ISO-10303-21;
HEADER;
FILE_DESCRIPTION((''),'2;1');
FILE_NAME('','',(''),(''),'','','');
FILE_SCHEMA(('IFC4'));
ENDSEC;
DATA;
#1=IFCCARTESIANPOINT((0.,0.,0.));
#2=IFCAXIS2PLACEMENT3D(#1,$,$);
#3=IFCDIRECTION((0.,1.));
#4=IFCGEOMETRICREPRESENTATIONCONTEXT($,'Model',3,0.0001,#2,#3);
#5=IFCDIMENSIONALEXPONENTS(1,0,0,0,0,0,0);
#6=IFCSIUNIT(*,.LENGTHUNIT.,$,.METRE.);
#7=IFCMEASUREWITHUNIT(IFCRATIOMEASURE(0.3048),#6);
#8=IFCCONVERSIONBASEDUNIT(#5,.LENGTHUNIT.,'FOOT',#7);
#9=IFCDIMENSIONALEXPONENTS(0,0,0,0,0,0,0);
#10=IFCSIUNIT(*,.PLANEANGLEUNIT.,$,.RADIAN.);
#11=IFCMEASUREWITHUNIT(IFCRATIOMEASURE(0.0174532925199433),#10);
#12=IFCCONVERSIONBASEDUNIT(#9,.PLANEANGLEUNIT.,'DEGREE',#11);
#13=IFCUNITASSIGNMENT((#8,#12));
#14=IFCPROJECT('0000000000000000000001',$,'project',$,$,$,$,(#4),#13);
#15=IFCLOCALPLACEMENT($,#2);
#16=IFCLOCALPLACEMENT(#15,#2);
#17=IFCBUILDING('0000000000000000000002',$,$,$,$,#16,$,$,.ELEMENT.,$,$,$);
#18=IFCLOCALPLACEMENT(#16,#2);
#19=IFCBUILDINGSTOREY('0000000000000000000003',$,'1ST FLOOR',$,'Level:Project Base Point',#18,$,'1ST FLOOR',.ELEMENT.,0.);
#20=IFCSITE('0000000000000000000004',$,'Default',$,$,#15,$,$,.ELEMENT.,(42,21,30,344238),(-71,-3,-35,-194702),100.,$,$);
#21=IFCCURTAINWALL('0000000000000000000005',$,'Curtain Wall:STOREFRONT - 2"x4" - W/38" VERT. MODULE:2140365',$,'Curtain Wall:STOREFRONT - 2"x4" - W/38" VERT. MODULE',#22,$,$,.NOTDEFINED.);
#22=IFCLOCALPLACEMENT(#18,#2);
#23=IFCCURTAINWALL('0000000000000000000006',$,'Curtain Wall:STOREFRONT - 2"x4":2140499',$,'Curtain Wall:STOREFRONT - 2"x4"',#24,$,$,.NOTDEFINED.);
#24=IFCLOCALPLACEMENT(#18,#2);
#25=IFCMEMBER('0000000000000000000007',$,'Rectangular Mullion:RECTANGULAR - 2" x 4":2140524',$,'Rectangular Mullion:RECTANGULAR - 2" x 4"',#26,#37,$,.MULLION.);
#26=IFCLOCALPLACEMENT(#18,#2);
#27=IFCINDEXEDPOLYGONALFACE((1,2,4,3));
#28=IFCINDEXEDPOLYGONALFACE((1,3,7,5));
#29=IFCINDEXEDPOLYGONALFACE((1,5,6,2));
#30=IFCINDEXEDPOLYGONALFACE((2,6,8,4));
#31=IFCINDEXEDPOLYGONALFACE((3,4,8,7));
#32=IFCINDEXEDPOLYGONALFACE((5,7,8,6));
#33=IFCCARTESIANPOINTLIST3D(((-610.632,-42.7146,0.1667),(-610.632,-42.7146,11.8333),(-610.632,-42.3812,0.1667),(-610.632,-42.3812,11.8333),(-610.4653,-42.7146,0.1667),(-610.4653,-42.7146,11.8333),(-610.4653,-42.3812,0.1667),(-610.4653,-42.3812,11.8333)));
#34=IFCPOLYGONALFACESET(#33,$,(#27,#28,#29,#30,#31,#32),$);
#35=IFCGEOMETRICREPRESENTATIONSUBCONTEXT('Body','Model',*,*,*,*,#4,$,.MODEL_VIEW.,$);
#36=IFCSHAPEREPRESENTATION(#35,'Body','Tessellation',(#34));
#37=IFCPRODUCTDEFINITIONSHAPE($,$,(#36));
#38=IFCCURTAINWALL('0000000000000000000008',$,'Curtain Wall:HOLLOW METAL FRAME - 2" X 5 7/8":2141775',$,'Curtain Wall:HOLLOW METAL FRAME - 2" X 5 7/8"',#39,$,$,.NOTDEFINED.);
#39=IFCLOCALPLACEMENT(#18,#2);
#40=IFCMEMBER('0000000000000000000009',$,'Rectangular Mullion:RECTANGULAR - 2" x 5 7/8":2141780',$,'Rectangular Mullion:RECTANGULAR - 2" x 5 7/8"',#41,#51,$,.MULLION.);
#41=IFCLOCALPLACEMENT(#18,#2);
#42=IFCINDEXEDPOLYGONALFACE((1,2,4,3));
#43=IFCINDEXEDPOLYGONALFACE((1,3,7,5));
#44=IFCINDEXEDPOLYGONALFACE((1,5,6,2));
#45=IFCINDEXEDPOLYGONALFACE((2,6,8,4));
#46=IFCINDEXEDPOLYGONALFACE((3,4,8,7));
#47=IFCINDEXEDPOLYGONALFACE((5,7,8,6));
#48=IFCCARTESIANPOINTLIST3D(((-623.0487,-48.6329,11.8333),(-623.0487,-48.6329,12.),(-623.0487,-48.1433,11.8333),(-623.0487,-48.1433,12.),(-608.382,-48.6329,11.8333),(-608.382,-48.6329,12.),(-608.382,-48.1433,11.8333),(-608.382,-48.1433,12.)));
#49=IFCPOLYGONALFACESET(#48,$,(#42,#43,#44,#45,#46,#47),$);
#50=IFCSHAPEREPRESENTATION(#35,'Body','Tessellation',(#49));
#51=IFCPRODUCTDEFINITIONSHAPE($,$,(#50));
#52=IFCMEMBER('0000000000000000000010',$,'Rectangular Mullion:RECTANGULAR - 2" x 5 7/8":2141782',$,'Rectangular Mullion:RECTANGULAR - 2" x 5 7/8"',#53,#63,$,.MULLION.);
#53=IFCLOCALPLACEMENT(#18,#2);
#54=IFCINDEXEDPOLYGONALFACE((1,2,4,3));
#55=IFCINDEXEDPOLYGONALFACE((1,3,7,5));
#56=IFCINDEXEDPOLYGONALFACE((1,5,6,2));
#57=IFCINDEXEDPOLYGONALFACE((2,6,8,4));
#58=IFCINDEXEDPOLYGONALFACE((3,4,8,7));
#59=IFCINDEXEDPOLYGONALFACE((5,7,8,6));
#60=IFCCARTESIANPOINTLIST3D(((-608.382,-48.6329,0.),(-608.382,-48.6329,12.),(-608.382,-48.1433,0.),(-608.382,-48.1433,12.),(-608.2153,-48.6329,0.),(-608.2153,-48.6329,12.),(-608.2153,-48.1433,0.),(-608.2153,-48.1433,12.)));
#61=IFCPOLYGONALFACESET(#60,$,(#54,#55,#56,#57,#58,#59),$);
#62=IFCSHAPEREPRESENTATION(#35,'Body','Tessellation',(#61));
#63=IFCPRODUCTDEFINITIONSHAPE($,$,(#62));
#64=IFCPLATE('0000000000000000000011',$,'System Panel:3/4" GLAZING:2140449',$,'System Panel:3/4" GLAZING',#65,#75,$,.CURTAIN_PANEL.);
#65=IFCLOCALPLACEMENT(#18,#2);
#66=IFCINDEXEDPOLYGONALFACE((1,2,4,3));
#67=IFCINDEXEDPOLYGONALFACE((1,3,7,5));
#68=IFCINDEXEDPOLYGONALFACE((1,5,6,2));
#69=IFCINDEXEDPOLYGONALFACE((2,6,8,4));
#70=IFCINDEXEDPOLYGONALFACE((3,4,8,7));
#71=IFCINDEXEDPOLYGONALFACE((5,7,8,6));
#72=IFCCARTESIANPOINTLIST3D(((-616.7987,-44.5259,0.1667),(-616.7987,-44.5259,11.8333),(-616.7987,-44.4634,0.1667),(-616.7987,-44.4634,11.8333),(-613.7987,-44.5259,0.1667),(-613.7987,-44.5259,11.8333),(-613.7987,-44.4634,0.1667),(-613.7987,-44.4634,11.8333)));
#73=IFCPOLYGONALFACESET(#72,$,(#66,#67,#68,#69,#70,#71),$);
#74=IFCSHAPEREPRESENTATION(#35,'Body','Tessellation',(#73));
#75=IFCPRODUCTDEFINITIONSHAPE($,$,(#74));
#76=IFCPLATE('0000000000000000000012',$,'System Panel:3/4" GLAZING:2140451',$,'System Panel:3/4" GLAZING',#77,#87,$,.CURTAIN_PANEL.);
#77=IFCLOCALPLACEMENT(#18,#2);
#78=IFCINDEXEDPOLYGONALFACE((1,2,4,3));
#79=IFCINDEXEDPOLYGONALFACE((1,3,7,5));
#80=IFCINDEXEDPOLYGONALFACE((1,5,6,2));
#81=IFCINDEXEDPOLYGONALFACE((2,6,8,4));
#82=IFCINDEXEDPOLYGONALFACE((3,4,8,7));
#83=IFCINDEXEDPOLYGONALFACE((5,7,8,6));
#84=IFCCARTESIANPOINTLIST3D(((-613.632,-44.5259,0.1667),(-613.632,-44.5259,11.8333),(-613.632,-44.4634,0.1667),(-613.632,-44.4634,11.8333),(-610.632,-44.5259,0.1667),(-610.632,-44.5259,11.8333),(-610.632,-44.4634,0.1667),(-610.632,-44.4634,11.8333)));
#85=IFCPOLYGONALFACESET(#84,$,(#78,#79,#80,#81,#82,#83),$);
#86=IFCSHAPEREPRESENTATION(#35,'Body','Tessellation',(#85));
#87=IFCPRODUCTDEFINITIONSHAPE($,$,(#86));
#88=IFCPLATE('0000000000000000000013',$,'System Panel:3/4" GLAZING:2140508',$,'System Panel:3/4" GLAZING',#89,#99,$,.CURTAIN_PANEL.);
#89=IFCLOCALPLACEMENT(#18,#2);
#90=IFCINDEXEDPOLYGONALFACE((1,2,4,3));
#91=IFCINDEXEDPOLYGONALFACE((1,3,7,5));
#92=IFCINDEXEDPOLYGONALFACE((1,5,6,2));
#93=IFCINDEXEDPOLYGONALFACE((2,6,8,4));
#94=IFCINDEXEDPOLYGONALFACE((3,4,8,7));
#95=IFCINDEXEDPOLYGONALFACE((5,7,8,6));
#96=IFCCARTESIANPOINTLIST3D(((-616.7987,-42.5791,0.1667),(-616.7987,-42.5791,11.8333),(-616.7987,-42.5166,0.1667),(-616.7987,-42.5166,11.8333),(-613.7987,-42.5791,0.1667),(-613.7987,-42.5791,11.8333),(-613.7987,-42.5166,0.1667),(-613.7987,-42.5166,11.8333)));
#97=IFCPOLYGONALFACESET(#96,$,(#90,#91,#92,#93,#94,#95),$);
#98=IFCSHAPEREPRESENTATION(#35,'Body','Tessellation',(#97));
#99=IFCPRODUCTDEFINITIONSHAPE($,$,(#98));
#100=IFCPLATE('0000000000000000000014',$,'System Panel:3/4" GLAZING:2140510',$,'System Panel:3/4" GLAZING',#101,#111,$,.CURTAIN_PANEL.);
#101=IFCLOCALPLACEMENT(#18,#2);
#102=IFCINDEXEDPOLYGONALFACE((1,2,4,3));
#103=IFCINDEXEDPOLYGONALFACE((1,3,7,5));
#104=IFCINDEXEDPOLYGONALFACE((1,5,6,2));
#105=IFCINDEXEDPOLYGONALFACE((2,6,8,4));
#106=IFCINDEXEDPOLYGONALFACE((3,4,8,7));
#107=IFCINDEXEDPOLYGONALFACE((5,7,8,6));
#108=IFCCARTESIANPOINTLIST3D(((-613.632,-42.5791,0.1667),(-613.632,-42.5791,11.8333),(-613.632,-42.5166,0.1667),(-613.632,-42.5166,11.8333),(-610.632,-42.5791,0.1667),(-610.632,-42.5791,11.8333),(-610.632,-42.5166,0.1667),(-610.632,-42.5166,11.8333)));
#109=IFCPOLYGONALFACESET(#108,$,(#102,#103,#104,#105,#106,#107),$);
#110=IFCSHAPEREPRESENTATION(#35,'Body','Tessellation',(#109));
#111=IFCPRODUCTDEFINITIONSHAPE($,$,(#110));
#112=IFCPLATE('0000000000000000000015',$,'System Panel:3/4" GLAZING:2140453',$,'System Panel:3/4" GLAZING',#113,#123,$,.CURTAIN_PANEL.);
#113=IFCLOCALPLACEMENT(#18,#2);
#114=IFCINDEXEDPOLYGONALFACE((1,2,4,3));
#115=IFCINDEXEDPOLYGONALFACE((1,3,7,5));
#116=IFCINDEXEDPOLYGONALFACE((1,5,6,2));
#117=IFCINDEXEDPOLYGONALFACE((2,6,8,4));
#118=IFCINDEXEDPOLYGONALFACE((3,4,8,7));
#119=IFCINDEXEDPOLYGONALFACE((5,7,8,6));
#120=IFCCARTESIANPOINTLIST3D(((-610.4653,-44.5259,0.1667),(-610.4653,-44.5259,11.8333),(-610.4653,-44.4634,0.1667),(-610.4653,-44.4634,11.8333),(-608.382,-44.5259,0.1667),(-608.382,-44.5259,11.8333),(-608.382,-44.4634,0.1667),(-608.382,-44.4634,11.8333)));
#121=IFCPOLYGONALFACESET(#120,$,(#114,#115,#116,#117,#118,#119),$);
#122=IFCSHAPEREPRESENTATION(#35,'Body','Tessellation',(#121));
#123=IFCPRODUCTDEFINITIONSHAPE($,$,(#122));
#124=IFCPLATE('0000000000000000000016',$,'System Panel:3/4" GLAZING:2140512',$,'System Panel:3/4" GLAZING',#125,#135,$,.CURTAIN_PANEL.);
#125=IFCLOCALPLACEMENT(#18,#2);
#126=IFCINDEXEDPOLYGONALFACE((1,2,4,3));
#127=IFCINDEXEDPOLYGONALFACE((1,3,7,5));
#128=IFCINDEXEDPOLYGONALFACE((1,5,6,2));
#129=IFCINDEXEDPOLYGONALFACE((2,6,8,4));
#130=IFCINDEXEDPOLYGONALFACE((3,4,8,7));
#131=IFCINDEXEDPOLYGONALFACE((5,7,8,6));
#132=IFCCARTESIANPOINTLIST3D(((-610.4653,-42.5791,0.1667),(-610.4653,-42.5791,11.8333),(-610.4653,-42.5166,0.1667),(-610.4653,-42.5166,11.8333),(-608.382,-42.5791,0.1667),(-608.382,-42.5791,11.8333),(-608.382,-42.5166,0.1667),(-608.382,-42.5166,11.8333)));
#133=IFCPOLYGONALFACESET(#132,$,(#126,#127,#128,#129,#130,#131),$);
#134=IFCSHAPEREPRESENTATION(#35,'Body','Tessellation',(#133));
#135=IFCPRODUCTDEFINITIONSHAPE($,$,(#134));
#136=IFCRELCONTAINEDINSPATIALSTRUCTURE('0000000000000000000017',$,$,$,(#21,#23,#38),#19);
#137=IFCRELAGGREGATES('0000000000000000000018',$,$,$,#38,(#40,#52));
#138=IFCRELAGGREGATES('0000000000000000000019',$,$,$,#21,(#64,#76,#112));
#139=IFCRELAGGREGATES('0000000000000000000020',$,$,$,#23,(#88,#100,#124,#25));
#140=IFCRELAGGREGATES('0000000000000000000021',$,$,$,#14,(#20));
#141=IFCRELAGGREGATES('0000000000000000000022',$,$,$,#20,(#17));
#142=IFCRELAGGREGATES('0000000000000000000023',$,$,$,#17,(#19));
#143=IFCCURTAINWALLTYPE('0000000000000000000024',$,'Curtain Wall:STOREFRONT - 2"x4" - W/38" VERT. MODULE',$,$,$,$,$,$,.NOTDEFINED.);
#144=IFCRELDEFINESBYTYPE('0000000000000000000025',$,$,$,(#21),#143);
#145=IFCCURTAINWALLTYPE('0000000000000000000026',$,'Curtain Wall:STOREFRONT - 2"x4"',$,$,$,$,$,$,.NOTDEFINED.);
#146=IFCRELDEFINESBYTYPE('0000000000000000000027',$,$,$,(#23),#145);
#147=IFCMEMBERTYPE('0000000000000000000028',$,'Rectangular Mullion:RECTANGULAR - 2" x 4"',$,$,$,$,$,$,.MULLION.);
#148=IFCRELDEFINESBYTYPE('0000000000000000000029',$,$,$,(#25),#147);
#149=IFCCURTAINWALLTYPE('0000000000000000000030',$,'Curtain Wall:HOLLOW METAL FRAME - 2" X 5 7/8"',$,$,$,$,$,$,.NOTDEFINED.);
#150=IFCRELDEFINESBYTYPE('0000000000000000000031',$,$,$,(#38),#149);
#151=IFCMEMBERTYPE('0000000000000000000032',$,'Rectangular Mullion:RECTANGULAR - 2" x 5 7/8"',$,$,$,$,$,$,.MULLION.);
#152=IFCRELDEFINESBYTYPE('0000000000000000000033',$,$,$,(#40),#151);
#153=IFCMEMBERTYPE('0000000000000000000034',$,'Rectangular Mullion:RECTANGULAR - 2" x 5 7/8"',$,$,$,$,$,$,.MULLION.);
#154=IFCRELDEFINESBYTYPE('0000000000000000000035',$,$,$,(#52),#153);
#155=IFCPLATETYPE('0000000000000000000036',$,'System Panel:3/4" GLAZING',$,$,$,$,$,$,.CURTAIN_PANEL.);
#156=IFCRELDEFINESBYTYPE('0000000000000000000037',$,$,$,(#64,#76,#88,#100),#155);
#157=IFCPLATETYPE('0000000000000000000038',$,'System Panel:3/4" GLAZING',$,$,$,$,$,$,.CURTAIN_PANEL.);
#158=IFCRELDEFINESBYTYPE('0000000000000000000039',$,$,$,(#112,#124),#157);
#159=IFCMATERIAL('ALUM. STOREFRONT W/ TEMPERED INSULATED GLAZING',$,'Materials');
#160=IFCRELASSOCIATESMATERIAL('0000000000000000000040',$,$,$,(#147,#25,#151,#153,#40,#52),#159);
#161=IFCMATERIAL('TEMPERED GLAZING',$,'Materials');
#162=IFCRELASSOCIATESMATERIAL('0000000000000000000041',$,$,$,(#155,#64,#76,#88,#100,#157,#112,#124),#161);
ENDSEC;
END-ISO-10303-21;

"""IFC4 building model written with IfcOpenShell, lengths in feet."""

from ifc_helpers import new_model, entity, si_unit, converted_unit, direction, frame, origin, origin_2d_with_axis, place, context, subcontext, project, spatial, rectangle, extrude, source, transform, mapped, material, material_profile, profile_set, profile_usage, type_object, type_shapes, element, aggregate, save


model = new_model("IFC4")

# Units and contexts
model_context = context("Model", 3, precision=0.0001, world=origin(), true_north=direction((0.0, 1.0)))
body_context = subcontext(model_context, "Body", "Model", "MODEL_VIEW")
ifc_project = project(units=[converted_unit("LENGTHUNIT", "FOOT", entity("IfcRatioMeasure", 0.3048), si_unit("LENGTHUNIT", "METRE"), dimensions=[1, 0, 0, 0, 0, 0, 0]), converted_unit("PLANEANGLEUNIT", "DEGREE", entity("IfcRatioMeasure", 0.0174532925199433), si_unit("PLANEANGLEUNIT", "RADIAN"), dimensions=[0, 0, 0, 0, 0, 0, 0])], contexts=[model_context])

# Site, building, storey
site_placement = place(None, origin())
site = spatial("IfcSite", under=ifc_project, at=site_placement, Name="Default", CompositionType="ELEMENT", RefLatitude=(42, 21, 30, 344238), RefLongitude=(-71, -3, -35, -194702), RefElevation=100.0)
building_placement = place(site_placement, origin())
building = spatial("IfcBuilding", under=site, at=building_placement, CompositionType="ELEMENT")
storey_placement = place(building_placement, origin())
storey = spatial("IfcBuildingStorey", under=building, at=storey_placement, Name="1ST FLOOR", ObjectType="Level:Project Base Point", LongName="1ST FLOOR", CompositionType="ELEMENT", Elevation=0.0)

# Curtain walls
curtain_wall_type_1 = type_object("IfcCurtainWallType", Name="Curtain Wall:STOREFRONT - 2\"x4\" - W/38\" VERT. MODULE", PredefinedType="NOTDEFINED")
curtain_wall_1_placement = place(storey_placement, origin())
curtain_wall_1 = element("IfcCurtainWall", 1, at=curtain_wall_1_placement, inside=storey, type_object=curtain_wall_type_1, Name="Curtain Wall:STOREFRONT - 2\"x4\" - W/38\" VERT. MODULE:2140365", ObjectType="Curtain Wall:STOREFRONT - 2\"x4\" - W/38\" VERT. MODULE", PredefinedType="NOTDEFINED")
ifc_material_1 = material(Name="ALUM. STOREFRONT W/ TEMPERED INSULATED GLAZING", Category="Materials")
ifc_material_profile_1 = material_profile(ifc_material_1, rectangle(XDim=0.3333, YDim=0.1667, at=origin_2d_with_axis()), Name="RECTANGULAR - 2\" x 4\"")
ifc_profile_set_1 = profile_set([ifc_material_profile_1], Name="RECTANGULAR - 2\" x 4\"")
curtain_wall_type_2 = type_object("IfcCurtainWallType", Name="Curtain Wall:STOREFRONT - 2\"x4\"", PredefinedType="NOTDEFINED")
curtain_wall_2_placement = place(storey_placement, origin())
curtain_wall_2 = element("IfcCurtainWall", 2, at=curtain_wall_2_placement, inside=storey, type_object=curtain_wall_type_2, Name="Curtain Wall:STOREFRONT - 2\"x4\":2140499", ObjectType="Curtain Wall:STOREFRONT - 2\"x4\"", PredefinedType="NOTDEFINED")

# Member
member_type_1 = type_object("IfcMemberType", Name="Rectangular Mullion:RECTANGULAR - 2\" x 4\"", PredefinedType="MULLION", material=ifc_profile_set_1)
shared_shape_1 = source(origin(), body_context, "Body", "SweptSolid", [
    extrude(rectangle(XDim=0.3333, YDim=0.1667, at=origin_2d_with_axis()), frame((0.0, 0.0, -11.6667), z_axis=(0.0, 0.0, 1.0), x_axis=(0.0, -1.0, 0.0)), (0.0, 0.0, 1.0), 11.6667),
])
type_shapes(member_type_1, [shared_shape_1])
ifc_profile_usage_1 = profile_usage(ifc_profile_set_1)
member_1_placement = place(storey_placement, frame((-610.5487, -42.5479, 0.1667), z_axis=(0.0, 0.0, -1.0), x_axis=(1.0, 0.0, 0.0)))
member_1 = element("IfcMember", 3, at=member_1_placement, type_object=member_type_1, material=ifc_profile_usage_1, Name="Rectangular Mullion:RECTANGULAR - 2\" x 4\":2140524", ObjectType="Rectangular Mullion:RECTANGULAR - 2\" x 4\"", PredefinedType="MULLION", context=body_context, shape_type="MappedRepresentation", body=[
    mapped(shared_shape_1, transform((0.0, 0.0, 0.0), scale=1.0)),
])

# Curtain wall, members
curtain_wall_type_3 = type_object("IfcCurtainWallType", Name="Curtain Wall:HOLLOW METAL FRAME - 2\" X 5 7/8\"", PredefinedType="NOTDEFINED")
curtain_wall_3_placement = place(storey_placement, origin())
curtain_wall_3 = element("IfcCurtainWall", 4, at=curtain_wall_3_placement, inside=storey, type_object=curtain_wall_type_3, Name="Curtain Wall:HOLLOW METAL FRAME - 2\" X 5 7/8\":2141775", ObjectType="Curtain Wall:HOLLOW METAL FRAME - 2\" X 5 7/8\"", PredefinedType="NOTDEFINED")
ifc_material_profile_2 = material_profile(ifc_material_1, rectangle(XDim=0.4896, YDim=0.1667, at=origin_2d_with_axis()), Name="RECTANGULAR - 2\" x 5 7/8\"")
ifc_profile_set_2 = profile_set([ifc_material_profile_2], Name="RECTANGULAR - 2\" x 5 7/8\"")
ifc_profile_usage_2 = profile_usage(ifc_profile_set_2)
member_type_2 = type_object("IfcMemberType", Name="Rectangular Mullion:RECTANGULAR - 2\" x 5 7/8\"", PredefinedType="MULLION", material=ifc_profile_set_2)
shared_shape_2 = source(origin(), body_context, "Body", "SweptSolid", [
    extrude(rectangle(XDim=0.4896, YDim=0.1667, at=origin_2d_with_axis()), frame((-0.0833, 0.0, -14.6667), z_axis=(0.0, 0.0, 1.0), x_axis=(0.0, -1.0, 0.0)), (0.0, 0.0, 1.0), 14.6667),
])
type_shapes(member_type_2, [shared_shape_2])
member_2_placement = place(storey_placement, frame((-608.382, -48.3881, 12.0), z_axis=(1.0, 0.0, 0.0), x_axis=(0.0, 0.0, 1.0)))
member_2 = element("IfcMember", 5, at=member_2_placement, type_object=member_type_2, material=ifc_profile_usage_2, Name="Rectangular Mullion:RECTANGULAR - 2\" x 5 7/8\":2141780", ObjectType="Rectangular Mullion:RECTANGULAR - 2\" x 5 7/8\"", PredefinedType="MULLION", context=body_context, shape_type="MappedRepresentation", body=[
    mapped(shared_shape_2, transform((0.0, 0.0, 0.0), scale=1.0)),
])
ifc_profile_usage_3 = profile_usage(ifc_profile_set_2)
member_type_3 = type_object("IfcMemberType", Name="Rectangular Mullion:RECTANGULAR - 2\" x 5 7/8\"", PredefinedType="MULLION", material=ifc_profile_set_2)
shared_shape_3 = source(origin(), body_context, "Body", "SweptSolid", [
    extrude(rectangle(XDim=0.4896, YDim=0.1667, at=origin_2d_with_axis()), frame((-0.0833, 0.0, -12.0), z_axis=(0.0, 0.0, 1.0), x_axis=(0.0, -1.0, 0.0)), (0.0, 0.0, 1.0), 12.0),
])
type_shapes(member_type_3, [shared_shape_3])
member_3_placement = place(storey_placement, frame((-608.2153, -48.3881, 0.0), z_axis=(0.0, 0.0, -1.0), x_axis=(1.0, 0.0, 0.0)))
member_3 = element("IfcMember", 6, at=member_3_placement, type_object=member_type_3, material=ifc_profile_usage_3, Name="Rectangular Mullion:RECTANGULAR - 2\" x 5 7/8\":2141782", ObjectType="Rectangular Mullion:RECTANGULAR - 2\" x 5 7/8\"", PredefinedType="MULLION", context=body_context, shape_type="MappedRepresentation", body=[
    mapped(shared_shape_3, transform((0.0, 0.0, 0.0), scale=1.0)),
])
aggregate(curtain_wall_3, [member_2, member_3])

# Plates
ifc_material_2 = material(Name="TEMPERED GLAZING", Category="Materials")
plate_type_1 = type_object("IfcPlateType", Name="System Panel:3/4\" GLAZING", PredefinedType="CURTAIN_PANEL", material=ifc_material_2)
shared_shape_4 = source(origin(), body_context, "Body", "SweptSolid", [
    extrude(rectangle(XDim=0.0625, YDim=3.0, at=origin_2d_with_axis()), frame((0.0, 0.0, 0.0), z_axis=(0.0, 0.0, 1.0), x_axis=(0.0, 1.0, 0.0)), (0.0, 0.0, 1.0), 11.6667),
])
type_shapes(plate_type_1, [shared_shape_4])
plate_1_placement = place(curtain_wall_1_placement, frame((-615.2987, -44.4946, 0.1667)))
plate_1 = element("IfcPlate", 7, at=plate_1_placement, type_object=plate_type_1, material=ifc_material_2, Name="System Panel:3/4\" GLAZING:2140449", ObjectType="System Panel:3/4\" GLAZING", PredefinedType="CURTAIN_PANEL", context=body_context, shape_type="MappedRepresentation", body=[
    mapped(shared_shape_4, transform((0.0, 0.0, 0.0), scale=1.0)),
])
plate_2_placement = place(curtain_wall_1_placement, frame((-612.132, -44.4946, 0.1667)))
plate_2 = element("IfcPlate", 8, at=plate_2_placement, type_object=plate_type_1, material=ifc_material_2, Name="System Panel:3/4\" GLAZING:2140451", ObjectType="System Panel:3/4\" GLAZING", PredefinedType="CURTAIN_PANEL", context=body_context, shape_type="MappedRepresentation", body=[
    mapped(shared_shape_4, transform((0.0, 0.0, 0.0), scale=1.0)),
])
plate_3_placement = place(curtain_wall_2_placement, frame((-615.2987, -42.5479, 0.1667)))
plate_3 = element("IfcPlate", 9, at=plate_3_placement, type_object=plate_type_1, material=ifc_material_2, Name="System Panel:3/4\" GLAZING:2140508", ObjectType="System Panel:3/4\" GLAZING", PredefinedType="CURTAIN_PANEL", context=body_context, shape_type="MappedRepresentation", body=[
    mapped(shared_shape_4, transform((0.0, 0.0, 0.0), scale=1.0)),
])
plate_4_placement = place(curtain_wall_2_placement, frame((-612.132, -42.5479, 0.1667)))
plate_4 = element("IfcPlate", 10, at=plate_4_placement, type_object=plate_type_1, material=ifc_material_2, Name="System Panel:3/4\" GLAZING:2140510", ObjectType="System Panel:3/4\" GLAZING", PredefinedType="CURTAIN_PANEL", context=body_context, shape_type="MappedRepresentation", body=[
    mapped(shared_shape_4, transform((0.0, 0.0, 0.0), scale=1.0)),
])
plate_type_2 = type_object("IfcPlateType", Name="System Panel:3/4\" GLAZING", PredefinedType="CURTAIN_PANEL", material=ifc_material_2)
shared_shape_5 = source(origin(), body_context, "Body", "SweptSolid", [
    extrude(rectangle(XDim=0.0625, YDim=2.0833, at=origin_2d_with_axis()), frame((0.0, 0.0, 0.0), z_axis=(0.0, 0.0, 1.0), x_axis=(0.0, 1.0, 0.0)), (0.0, 0.0, 1.0), 11.6667),
])
type_shapes(plate_type_2, [shared_shape_5])
plate_5_placement = place(curtain_wall_1_placement, frame((-609.4237, -44.4946, 0.1667)))
plate_5 = element("IfcPlate", 11, at=plate_5_placement, type_object=plate_type_2, material=ifc_material_2, Name="System Panel:3/4\" GLAZING:2140453", ObjectType="System Panel:3/4\" GLAZING", PredefinedType="CURTAIN_PANEL", context=body_context, shape_type="MappedRepresentation", body=[
    mapped(shared_shape_5, transform((0.0, 0.0, 0.0), scale=1.0)),
])
aggregate(curtain_wall_1, [plate_1, plate_2, plate_5])
plate_6_placement = place(curtain_wall_2_placement, frame((-609.4237, -42.5479, 0.1667)))
plate_6 = element("IfcPlate", 12, at=plate_6_placement, type_object=plate_type_2, material=ifc_material_2, Name="System Panel:3/4\" GLAZING:2140512", ObjectType="System Panel:3/4\" GLAZING", PredefinedType="CURTAIN_PANEL", context=body_context, shape_type="MappedRepresentation", body=[
    mapped(shared_shape_5, transform((0.0, 0.0, 0.0), scale=1.0)),
])
aggregate(curtain_wall_2, [plate_3, plate_4, plate_6, member_1])

save(model, "model.ifc")
